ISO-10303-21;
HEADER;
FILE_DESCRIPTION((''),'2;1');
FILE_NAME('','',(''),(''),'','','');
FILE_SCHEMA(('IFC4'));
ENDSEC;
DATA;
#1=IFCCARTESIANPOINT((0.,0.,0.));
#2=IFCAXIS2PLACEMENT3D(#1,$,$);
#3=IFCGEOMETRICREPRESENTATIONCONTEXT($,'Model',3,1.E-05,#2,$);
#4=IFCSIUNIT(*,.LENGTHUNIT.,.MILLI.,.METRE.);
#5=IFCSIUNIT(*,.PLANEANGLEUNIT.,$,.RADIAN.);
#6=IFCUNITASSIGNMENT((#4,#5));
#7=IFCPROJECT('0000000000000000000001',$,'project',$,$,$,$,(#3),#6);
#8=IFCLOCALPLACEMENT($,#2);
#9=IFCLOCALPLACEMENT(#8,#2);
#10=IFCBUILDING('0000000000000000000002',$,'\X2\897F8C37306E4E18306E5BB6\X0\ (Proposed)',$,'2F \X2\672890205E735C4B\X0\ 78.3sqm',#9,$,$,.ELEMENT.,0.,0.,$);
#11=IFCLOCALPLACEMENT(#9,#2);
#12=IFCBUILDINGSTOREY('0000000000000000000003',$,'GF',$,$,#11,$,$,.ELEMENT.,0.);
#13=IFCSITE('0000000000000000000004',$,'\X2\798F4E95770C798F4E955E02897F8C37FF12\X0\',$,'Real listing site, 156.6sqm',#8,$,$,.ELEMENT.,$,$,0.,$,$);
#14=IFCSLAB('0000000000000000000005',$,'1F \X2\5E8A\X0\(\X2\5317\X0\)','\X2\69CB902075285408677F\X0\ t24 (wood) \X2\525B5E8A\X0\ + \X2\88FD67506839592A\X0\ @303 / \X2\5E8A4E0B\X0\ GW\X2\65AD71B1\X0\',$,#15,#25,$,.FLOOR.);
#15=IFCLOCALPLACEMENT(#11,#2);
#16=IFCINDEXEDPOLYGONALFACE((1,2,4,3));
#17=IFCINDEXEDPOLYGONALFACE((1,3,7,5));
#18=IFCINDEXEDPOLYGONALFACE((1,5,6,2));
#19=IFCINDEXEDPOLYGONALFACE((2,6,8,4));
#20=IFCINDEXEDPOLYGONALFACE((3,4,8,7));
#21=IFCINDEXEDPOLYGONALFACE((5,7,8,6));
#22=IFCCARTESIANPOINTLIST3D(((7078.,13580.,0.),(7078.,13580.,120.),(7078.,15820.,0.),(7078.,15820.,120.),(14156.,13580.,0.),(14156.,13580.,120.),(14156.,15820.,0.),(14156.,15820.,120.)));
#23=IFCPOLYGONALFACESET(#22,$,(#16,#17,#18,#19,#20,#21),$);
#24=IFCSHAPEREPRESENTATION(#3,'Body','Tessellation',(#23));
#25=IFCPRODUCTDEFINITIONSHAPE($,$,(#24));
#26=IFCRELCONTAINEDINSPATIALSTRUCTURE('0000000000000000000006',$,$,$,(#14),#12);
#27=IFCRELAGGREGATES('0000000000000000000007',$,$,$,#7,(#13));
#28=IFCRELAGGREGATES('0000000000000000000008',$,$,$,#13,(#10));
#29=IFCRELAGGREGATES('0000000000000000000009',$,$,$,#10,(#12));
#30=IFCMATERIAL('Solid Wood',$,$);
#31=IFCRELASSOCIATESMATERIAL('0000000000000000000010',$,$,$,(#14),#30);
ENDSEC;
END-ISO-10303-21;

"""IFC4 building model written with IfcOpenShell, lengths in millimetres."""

from ifc_helpers import new_model, si_unit, frame, frame_2d, origin, place, context, project, spatial, rectangle, extrude, material, element, save


model = new_model("IFC4")

# Units and contexts
model_context = context("Model", 3, precision=1e-05, world=origin())
ifc_project = project(units=[si_unit("LENGTHUNIT", "METRE", prefix="MILLI"), si_unit("PLANEANGLEUNIT", "RADIAN")], contexts=[model_context])

# Site, building, storey
site_placement = place(None, origin())
site = spatial("IfcSite", under=ifc_project, at=site_placement, Name="福井県福井市西谷２", ObjectType="Real listing site, 156.6sqm", CompositionType="ELEMENT", RefElevation=0.0)
building_placement = place(site_placement, origin())
building = spatial("IfcBuilding", under=site, at=building_placement, Name="西谷の丘の家 (Proposed)", ObjectType="2F 木造平屋 78.3sqm", CompositionType="ELEMENT", ElevationOfRefHeight=0.0, ElevationOfTerrain=0.0)
storey_placement = place(building_placement, origin())
storey = spatial("IfcBuildingStorey", under=building, at=storey_placement, Name="GF", CompositionType="ELEMENT", Elevation=0.0)

# Slab
ifc_material_1 = material(Name="Solid Wood")
slab_1_placement = place(storey_placement, frame((3539.0, 6790.0, 0.0)))
element("IfcSlab", 1, at=slab_1_placement, inside=storey, material=ifc_material_1, Name="1F 床(北)", Description="構造用合板 t24 (wood) 剛床 + 製材根太 @303 / 床下 GW断熱", PredefinedType="FLOOR", context=model_context, shape_type="SweptSolid", body=[
    extrude(rectangle(XDim=7078.0, YDim=2240.0, at=frame_2d((3539.0, 1120.0))), frame((3539.0, 6790.0, 0.0)), (0.0, 0.0, 1.0), 120.0),
])

save(model, "model.ifc")
